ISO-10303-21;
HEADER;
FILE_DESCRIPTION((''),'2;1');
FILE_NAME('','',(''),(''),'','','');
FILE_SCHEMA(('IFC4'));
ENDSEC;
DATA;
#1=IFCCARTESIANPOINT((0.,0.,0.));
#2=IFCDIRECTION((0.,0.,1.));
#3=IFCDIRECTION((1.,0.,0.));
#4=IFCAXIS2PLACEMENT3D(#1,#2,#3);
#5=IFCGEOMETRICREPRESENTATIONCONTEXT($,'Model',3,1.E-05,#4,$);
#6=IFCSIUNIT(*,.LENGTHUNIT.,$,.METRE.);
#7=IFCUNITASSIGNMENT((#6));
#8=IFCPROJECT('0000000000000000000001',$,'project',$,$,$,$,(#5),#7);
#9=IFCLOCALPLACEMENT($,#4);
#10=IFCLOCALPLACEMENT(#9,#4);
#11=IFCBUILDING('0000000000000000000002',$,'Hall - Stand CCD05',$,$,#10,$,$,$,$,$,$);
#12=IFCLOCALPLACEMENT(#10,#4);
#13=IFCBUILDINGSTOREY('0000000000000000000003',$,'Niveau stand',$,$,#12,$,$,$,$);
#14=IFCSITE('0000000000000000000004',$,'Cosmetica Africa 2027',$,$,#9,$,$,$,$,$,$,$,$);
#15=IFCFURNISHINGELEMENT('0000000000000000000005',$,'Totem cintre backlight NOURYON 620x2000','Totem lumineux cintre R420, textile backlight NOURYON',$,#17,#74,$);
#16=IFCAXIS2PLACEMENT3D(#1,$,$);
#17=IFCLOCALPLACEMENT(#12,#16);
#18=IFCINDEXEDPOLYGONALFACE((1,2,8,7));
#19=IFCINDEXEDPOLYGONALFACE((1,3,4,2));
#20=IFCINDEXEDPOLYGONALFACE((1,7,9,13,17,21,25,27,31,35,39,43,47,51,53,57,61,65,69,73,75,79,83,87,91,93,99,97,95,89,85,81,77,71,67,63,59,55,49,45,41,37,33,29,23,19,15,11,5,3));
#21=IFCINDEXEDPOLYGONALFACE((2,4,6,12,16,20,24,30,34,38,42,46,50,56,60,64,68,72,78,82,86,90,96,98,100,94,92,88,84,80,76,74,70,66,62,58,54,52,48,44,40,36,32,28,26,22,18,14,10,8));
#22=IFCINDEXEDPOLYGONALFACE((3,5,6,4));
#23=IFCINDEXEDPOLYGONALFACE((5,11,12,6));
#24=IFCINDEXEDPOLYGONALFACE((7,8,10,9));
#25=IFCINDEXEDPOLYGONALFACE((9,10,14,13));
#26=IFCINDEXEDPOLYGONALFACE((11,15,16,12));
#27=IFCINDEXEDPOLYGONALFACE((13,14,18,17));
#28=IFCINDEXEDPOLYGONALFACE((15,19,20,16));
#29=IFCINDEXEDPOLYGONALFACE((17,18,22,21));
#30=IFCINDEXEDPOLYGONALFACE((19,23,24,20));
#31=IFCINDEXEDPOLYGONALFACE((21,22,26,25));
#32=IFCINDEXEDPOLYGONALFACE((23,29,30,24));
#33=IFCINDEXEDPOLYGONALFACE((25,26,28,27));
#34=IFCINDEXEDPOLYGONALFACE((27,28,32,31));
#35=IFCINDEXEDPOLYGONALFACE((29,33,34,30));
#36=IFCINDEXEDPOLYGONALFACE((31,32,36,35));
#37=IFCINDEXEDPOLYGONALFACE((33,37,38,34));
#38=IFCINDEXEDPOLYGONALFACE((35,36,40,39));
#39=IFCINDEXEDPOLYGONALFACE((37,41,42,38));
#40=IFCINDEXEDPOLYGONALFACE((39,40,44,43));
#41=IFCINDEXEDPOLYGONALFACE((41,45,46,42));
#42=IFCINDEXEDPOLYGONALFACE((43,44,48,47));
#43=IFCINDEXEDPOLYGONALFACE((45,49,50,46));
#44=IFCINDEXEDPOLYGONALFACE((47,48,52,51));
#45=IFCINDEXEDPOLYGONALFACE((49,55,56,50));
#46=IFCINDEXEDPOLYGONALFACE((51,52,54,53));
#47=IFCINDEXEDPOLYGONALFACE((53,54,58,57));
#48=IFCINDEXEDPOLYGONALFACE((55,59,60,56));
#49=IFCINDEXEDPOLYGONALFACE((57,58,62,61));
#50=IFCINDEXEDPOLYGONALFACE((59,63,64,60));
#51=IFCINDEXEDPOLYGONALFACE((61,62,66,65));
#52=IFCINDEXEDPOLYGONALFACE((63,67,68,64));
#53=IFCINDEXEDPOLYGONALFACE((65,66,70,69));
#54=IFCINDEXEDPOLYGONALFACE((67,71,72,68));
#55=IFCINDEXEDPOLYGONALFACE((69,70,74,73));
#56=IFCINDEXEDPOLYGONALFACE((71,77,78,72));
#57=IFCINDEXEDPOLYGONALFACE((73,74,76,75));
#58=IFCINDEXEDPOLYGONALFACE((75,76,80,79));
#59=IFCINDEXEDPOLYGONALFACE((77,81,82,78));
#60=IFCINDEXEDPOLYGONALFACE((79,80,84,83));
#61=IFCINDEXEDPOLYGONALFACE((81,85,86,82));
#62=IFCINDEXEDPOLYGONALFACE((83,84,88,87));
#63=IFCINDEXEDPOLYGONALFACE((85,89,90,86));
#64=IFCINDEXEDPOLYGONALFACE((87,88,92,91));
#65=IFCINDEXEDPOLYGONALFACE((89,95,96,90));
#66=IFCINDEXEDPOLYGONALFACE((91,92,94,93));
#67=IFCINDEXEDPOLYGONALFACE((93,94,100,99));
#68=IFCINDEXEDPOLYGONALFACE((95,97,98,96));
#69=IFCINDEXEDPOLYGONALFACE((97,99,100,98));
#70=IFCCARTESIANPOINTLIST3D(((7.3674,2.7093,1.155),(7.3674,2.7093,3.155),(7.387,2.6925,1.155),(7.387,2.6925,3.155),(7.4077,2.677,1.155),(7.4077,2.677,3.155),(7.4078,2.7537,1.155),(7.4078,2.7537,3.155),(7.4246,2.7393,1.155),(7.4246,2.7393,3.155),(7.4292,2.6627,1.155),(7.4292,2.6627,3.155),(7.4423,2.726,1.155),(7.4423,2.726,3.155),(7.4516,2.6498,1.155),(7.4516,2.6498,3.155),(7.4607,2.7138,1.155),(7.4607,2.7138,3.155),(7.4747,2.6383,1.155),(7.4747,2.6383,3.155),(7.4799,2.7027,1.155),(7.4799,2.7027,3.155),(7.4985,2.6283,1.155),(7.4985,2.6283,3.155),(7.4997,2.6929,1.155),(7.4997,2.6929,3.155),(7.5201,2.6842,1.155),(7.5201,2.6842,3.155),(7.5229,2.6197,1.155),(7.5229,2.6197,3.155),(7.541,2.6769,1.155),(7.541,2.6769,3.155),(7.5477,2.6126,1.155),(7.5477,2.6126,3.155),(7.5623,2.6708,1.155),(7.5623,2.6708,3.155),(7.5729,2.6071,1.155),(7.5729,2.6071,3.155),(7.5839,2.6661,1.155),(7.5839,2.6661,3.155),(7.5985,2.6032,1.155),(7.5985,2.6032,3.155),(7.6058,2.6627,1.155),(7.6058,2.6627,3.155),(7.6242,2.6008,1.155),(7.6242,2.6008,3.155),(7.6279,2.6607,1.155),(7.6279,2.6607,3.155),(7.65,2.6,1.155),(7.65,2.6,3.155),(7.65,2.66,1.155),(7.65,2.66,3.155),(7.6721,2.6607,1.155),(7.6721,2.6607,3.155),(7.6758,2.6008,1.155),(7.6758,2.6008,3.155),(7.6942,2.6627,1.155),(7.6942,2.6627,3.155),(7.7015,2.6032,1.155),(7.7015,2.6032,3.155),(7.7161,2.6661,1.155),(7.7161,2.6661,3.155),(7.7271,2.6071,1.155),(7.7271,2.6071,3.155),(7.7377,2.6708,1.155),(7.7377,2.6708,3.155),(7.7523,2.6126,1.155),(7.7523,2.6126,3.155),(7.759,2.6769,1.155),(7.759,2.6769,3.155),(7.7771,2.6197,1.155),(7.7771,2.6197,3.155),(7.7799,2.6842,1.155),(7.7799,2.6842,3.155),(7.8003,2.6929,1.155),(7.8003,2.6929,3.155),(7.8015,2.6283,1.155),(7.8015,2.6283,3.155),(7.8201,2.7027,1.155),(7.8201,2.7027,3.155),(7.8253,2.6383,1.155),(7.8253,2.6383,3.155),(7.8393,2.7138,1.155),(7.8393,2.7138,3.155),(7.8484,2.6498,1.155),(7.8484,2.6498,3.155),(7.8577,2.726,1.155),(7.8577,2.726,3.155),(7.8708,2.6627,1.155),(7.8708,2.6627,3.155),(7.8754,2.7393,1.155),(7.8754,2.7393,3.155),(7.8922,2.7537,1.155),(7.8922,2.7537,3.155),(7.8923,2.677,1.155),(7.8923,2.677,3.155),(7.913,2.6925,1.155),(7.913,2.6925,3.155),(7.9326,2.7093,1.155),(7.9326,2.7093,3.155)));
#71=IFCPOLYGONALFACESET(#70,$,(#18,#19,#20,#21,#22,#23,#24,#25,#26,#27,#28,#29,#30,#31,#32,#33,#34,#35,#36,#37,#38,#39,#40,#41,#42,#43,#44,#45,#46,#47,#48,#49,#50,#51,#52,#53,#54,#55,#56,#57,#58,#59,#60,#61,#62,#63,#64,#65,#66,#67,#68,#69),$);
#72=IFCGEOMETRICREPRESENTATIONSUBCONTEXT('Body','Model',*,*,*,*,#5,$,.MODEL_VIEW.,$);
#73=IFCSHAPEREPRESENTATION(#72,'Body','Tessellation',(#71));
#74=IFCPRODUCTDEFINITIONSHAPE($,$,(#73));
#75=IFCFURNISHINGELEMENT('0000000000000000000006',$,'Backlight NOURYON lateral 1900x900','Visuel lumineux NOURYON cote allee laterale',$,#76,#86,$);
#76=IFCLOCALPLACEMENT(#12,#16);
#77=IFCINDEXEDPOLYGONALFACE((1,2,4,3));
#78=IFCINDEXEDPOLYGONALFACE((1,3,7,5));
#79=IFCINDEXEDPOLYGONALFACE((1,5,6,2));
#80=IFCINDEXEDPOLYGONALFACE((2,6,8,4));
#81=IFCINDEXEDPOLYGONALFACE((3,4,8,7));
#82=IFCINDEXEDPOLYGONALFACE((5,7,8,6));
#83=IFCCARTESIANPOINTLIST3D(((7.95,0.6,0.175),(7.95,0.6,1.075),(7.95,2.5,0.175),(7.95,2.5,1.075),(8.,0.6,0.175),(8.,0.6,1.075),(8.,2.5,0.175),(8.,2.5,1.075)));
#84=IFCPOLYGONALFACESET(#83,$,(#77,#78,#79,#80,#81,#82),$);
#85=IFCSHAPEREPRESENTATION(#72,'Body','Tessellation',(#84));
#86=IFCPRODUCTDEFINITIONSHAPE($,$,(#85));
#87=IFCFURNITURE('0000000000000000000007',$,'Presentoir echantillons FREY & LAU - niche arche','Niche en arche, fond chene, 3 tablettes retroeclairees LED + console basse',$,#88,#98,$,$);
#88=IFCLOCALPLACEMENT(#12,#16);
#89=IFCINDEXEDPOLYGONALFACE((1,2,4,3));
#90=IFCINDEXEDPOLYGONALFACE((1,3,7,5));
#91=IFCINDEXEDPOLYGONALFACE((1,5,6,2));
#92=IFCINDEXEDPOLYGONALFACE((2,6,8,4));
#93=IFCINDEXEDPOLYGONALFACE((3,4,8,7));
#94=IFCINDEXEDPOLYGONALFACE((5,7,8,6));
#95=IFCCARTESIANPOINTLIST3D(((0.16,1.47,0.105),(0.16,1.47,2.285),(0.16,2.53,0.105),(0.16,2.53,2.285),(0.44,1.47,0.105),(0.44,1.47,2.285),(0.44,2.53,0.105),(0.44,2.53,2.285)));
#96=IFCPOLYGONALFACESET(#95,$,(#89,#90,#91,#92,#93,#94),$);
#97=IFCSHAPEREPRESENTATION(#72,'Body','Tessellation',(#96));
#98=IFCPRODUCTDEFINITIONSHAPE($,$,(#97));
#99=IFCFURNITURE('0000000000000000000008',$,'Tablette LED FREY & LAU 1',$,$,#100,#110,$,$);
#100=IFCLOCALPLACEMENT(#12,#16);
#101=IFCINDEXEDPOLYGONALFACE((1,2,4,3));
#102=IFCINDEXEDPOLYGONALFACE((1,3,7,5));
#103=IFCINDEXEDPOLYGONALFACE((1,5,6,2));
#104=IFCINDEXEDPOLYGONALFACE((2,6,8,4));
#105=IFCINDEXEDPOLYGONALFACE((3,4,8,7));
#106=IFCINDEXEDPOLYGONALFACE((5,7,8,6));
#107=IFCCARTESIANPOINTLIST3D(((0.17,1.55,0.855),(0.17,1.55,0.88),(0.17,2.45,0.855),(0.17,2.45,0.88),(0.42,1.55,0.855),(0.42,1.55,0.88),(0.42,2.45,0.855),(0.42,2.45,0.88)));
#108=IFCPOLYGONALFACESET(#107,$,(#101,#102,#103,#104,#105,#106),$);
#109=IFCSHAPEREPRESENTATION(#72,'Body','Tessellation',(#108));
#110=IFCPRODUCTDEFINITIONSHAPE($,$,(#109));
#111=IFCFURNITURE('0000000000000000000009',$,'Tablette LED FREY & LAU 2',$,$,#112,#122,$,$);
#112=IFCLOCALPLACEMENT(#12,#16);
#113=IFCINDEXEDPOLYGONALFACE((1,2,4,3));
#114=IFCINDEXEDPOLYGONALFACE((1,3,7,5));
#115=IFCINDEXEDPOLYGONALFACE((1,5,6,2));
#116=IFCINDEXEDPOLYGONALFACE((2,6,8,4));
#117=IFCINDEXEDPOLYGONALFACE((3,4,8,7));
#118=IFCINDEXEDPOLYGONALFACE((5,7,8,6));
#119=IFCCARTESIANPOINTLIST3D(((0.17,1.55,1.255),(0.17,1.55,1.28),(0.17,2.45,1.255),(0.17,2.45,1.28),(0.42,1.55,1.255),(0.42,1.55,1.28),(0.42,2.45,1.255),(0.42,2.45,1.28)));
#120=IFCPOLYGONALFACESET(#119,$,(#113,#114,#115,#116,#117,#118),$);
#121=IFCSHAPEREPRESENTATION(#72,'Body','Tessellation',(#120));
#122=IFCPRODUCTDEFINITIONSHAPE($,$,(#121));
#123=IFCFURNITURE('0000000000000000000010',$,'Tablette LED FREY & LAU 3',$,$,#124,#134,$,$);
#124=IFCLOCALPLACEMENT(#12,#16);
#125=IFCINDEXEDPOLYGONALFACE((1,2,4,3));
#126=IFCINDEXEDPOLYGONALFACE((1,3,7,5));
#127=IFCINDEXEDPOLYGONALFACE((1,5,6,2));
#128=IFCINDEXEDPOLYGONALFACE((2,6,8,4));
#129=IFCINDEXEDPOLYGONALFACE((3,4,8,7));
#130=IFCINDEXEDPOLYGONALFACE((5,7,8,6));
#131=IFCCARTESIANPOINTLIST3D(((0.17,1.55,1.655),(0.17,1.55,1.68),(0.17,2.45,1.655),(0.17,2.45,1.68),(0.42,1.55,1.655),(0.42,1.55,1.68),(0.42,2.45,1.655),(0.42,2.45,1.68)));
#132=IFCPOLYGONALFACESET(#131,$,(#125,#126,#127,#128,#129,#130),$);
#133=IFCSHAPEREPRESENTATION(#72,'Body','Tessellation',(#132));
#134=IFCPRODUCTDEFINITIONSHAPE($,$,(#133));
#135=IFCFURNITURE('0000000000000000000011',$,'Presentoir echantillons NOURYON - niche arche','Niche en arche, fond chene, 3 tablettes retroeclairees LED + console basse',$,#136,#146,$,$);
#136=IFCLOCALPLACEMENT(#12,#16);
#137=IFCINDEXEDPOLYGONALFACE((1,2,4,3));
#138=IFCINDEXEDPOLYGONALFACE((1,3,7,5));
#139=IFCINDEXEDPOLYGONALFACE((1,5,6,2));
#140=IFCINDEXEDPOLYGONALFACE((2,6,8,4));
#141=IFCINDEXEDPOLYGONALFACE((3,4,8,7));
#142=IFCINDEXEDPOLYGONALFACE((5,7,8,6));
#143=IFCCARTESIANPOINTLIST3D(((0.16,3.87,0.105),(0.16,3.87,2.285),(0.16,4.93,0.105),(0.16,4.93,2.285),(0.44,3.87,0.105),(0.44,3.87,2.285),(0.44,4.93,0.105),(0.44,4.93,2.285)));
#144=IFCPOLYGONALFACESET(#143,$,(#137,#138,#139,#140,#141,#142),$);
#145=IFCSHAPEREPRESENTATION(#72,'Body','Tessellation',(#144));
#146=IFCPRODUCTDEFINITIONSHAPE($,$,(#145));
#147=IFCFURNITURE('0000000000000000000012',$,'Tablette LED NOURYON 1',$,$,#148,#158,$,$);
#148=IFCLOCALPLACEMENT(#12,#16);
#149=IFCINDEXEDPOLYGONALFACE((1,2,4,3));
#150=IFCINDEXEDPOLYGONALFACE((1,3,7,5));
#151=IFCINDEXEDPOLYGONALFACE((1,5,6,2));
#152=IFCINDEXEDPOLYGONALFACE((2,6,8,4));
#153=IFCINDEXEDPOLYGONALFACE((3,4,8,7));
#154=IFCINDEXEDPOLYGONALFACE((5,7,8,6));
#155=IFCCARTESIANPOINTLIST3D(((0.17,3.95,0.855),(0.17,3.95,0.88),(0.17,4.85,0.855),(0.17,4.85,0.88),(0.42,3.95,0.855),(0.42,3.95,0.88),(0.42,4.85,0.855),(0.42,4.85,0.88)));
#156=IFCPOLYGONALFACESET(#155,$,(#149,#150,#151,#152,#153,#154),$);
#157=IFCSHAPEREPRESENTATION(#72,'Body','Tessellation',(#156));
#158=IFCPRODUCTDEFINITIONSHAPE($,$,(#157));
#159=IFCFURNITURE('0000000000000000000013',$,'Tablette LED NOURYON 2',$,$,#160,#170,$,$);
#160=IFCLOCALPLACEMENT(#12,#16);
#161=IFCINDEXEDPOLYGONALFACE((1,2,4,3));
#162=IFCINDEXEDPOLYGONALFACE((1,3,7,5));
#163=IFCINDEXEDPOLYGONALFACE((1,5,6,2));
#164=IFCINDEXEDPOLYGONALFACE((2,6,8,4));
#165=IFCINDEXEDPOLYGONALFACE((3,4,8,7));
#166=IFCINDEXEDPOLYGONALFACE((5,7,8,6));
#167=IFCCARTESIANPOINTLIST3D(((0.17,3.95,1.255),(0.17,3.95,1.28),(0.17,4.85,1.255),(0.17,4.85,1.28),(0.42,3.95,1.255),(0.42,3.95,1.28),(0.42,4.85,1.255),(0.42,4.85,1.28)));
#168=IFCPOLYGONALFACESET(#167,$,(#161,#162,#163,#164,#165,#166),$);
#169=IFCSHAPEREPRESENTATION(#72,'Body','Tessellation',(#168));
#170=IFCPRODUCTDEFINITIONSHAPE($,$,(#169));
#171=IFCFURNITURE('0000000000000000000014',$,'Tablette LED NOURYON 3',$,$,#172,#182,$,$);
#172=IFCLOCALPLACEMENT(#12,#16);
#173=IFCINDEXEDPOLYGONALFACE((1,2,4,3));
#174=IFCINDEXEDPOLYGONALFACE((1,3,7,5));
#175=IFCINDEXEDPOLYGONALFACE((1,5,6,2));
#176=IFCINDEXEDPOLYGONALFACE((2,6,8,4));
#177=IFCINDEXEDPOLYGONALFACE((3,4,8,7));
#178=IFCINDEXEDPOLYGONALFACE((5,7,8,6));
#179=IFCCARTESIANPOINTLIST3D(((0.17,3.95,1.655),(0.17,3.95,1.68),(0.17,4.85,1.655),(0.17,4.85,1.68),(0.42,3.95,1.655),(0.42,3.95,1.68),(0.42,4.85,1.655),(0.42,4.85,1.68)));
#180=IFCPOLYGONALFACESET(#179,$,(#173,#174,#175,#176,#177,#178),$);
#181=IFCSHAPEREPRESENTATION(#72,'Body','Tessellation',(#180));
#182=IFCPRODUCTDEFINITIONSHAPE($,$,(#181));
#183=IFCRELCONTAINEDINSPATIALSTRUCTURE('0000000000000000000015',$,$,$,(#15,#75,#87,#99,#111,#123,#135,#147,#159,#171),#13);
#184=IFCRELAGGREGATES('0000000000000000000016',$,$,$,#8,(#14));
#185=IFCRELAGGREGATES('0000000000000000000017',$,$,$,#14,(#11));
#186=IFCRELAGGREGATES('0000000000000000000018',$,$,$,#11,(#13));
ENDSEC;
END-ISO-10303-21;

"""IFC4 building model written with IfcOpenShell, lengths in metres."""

from ifc_helpers import new_model, si_unit, frame, origin_with_axes, place, context, subcontext, project, spatial, polyline, outline, extrude, element, save


model = new_model("IFC4")

# Units and contexts
model_context = context("Model", 3, precision=1e-05, world=origin_with_axes())
body_context = subcontext(model_context, "Body", "Model", "MODEL_VIEW")
ifc_project = project(units=[si_unit("LENGTHUNIT", "METRE")], contexts=[model_context])

# Site, building, storey
site_placement = place(None, origin_with_axes())
site = spatial("IfcSite", under=ifc_project, at=site_placement, Name="Cosmetica Africa 2027")
building_placement = place(site_placement, origin_with_axes())
building = spatial("IfcBuilding", under=site, at=building_placement, Name="Hall - Stand CCD05")
storey_placement = place(building_placement, origin_with_axes())
storey = spatial("IfcBuildingStorey", under=building, at=storey_placement, Name="Niveau stand")

# Furnishing elements
furnishing_1_placement = place(storey_placement, origin_with_axes())
element("IfcFurnishingElement", 1, at=furnishing_1_placement, inside=storey, Name="Totem cintre backlight NOURYON 620x2000", Description="Totem lumineux cintre R420, textile backlight NOURYON", context=body_context, shape_type="SweptSolid", body=[
    extrude(outline(polyline([(7.3674, 2.7093), (7.387, 2.6925), (7.4077, 2.677), (7.4292, 2.6627), (7.4516, 2.6498), (7.4747, 2.6383), (7.4985, 2.6283), (7.5229, 2.6197), (7.5477, 2.6126), (7.5729, 2.6071), (7.5985, 2.6032), (7.6242, 2.6008), (7.65, 2.6), (7.6758, 2.6008), (7.7015, 2.6032), (7.7271, 2.6071), (7.7523, 2.6126), (7.7771, 2.6197), (7.8015, 2.6283), (7.8253, 2.6383), (7.8484, 2.6498), (7.8708, 2.6627), (7.8923, 2.677), (7.913, 2.6925), (7.9326, 2.7093), (7.8922, 2.7537), (7.8754, 2.7393), (7.8577, 2.726), (7.8393, 2.7138), (7.8201, 2.7027), (7.8003, 2.6929), (7.7799, 2.6842), (7.759, 2.6769), (7.7377, 2.6708), (7.7161, 2.6661), (7.6942, 2.6627), (7.6721, 2.6607), (7.65, 2.66), (7.6279, 2.6607), (7.6058, 2.6627), (7.5839, 2.6661), (7.5623, 2.6708), (7.541, 2.6769), (7.5201, 2.6842), (7.4997, 2.6929), (7.4799, 2.7027), (7.4607, 2.7138), (7.4423, 2.726), (7.4246, 2.7393), (7.4078, 2.7537), (7.3674, 2.7093)])), frame((0.0, 0.0, 1.155)), (0.0, 0.0, 1.0), 2.0),
])
furnishing_2_placement = place(storey_placement, origin_with_axes())
element("IfcFurnishingElement", 2, at=furnishing_2_placement, inside=storey, Name="Backlight NOURYON lateral 1900x900", Description="Visuel lumineux NOURYON cote allee laterale", context=body_context, shape_type="SweptSolid", body=[
    extrude(outline(polyline([(7.95, 0.6), (8.0, 0.6), (8.0, 2.5), (7.95, 2.5), (7.95, 0.6)])), frame((0.0, 0.0, 0.175)), (0.0, 0.0, 1.0), 0.9),
])

# Furniture
furniture_1_placement = place(storey_placement, origin_with_axes())
element("IfcFurniture", 3, at=furniture_1_placement, inside=storey, Name="Presentoir echantillons FREY & LAU - niche arche", Description="Niche en arche, fond chene, 3 tablettes retroeclairees LED + console basse", context=body_context, shape_type="SweptSolid", body=[
    extrude(outline(polyline([(0.16, 1.47), (0.44, 1.47), (0.44, 2.53), (0.16, 2.53), (0.16, 1.47)])), frame((0.0, 0.0, 0.105)), (0.0, 0.0, 1.0), 2.18),
])
furniture_2_placement = place(storey_placement, origin_with_axes())
element("IfcFurniture", 4, at=furniture_2_placement, inside=storey, Name="Tablette LED FREY & LAU 1", context=body_context, shape_type="SweptSolid", body=[
    extrude(outline(polyline([(0.17, 1.55), (0.42, 1.55), (0.42, 2.45), (0.17, 2.45), (0.17, 1.55)])), frame((0.0, 0.0, 0.855)), (0.0, 0.0, 1.0), 0.025),
])
furniture_3_placement = place(storey_placement, origin_with_axes())
element("IfcFurniture", 5, at=furniture_3_placement, inside=storey, Name="Tablette LED FREY & LAU 2", context=body_context, shape_type="SweptSolid", body=[
    extrude(outline(polyline([(0.17, 1.55), (0.42, 1.55), (0.42, 2.45), (0.17, 2.45), (0.17, 1.55)])), frame((0.0, 0.0, 1.255)), (0.0, 0.0, 1.0), 0.025),
])
furniture_4_placement = place(storey_placement, origin_with_axes())
element("IfcFurniture", 6, at=furniture_4_placement, inside=storey, Name="Tablette LED FREY & LAU 3", context=body_context, shape_type="SweptSolid", body=[
    extrude(outline(polyline([(0.17, 1.55), (0.42, 1.55), (0.42, 2.45), (0.17, 2.45), (0.17, 1.55)])), frame((0.0, 0.0, 1.655)), (0.0, 0.0, 1.0), 0.025),
])
furniture_5_placement = place(storey_placement, origin_with_axes())
element("IfcFurniture", 7, at=furniture_5_placement, inside=storey, Name="Presentoir echantillons NOURYON - niche arche", Description="Niche en arche, fond chene, 3 tablettes retroeclairees LED + console basse", context=body_context, shape_type="SweptSolid", body=[
    extrude(outline(polyline([(0.16, 3.87), (0.44, 3.87), (0.44, 4.93), (0.16, 4.93), (0.16, 3.87)])), frame((0.0, 0.0, 0.105)), (0.0, 0.0, 1.0), 2.18),
])
furniture_6_placement = place(storey_placement, origin_with_axes())
element("IfcFurniture", 8, at=furniture_6_placement, inside=storey, Name="Tablette LED NOURYON 1", context=body_context, shape_type="SweptSolid", body=[
    extrude(outline(polyline([(0.17, 3.95), (0.42, 3.95), (0.42, 4.85), (0.17, 4.85), (0.17, 3.95)])), frame((0.0, 0.0, 0.855)), (0.0, 0.0, 1.0), 0.025),
])
furniture_7_placement = place(storey_placement, origin_with_axes())
element("IfcFurniture", 9, at=furniture_7_placement, inside=storey, Name="Tablette LED NOURYON 2", context=body_context, shape_type="SweptSolid", body=[
    extrude(outline(polyline([(0.17, 3.95), (0.42, 3.95), (0.42, 4.85), (0.17, 4.85), (0.17, 3.95)])), frame((0.0, 0.0, 1.255)), (0.0, 0.0, 1.0), 0.025),
])
furniture_8_placement = place(storey_placement, origin_with_axes())
element("IfcFurniture", 10, at=furniture_8_placement, inside=storey, Name="Tablette LED NOURYON 3", context=body_context, shape_type="SweptSolid", body=[
    extrude(outline(polyline([(0.17, 3.95), (0.42, 3.95), (0.42, 4.85), (0.17, 4.85), (0.17, 3.95)])), frame((0.0, 0.0, 1.655)), (0.0, 0.0, 1.0), 0.025),
])

save(model, "model.ifc")
